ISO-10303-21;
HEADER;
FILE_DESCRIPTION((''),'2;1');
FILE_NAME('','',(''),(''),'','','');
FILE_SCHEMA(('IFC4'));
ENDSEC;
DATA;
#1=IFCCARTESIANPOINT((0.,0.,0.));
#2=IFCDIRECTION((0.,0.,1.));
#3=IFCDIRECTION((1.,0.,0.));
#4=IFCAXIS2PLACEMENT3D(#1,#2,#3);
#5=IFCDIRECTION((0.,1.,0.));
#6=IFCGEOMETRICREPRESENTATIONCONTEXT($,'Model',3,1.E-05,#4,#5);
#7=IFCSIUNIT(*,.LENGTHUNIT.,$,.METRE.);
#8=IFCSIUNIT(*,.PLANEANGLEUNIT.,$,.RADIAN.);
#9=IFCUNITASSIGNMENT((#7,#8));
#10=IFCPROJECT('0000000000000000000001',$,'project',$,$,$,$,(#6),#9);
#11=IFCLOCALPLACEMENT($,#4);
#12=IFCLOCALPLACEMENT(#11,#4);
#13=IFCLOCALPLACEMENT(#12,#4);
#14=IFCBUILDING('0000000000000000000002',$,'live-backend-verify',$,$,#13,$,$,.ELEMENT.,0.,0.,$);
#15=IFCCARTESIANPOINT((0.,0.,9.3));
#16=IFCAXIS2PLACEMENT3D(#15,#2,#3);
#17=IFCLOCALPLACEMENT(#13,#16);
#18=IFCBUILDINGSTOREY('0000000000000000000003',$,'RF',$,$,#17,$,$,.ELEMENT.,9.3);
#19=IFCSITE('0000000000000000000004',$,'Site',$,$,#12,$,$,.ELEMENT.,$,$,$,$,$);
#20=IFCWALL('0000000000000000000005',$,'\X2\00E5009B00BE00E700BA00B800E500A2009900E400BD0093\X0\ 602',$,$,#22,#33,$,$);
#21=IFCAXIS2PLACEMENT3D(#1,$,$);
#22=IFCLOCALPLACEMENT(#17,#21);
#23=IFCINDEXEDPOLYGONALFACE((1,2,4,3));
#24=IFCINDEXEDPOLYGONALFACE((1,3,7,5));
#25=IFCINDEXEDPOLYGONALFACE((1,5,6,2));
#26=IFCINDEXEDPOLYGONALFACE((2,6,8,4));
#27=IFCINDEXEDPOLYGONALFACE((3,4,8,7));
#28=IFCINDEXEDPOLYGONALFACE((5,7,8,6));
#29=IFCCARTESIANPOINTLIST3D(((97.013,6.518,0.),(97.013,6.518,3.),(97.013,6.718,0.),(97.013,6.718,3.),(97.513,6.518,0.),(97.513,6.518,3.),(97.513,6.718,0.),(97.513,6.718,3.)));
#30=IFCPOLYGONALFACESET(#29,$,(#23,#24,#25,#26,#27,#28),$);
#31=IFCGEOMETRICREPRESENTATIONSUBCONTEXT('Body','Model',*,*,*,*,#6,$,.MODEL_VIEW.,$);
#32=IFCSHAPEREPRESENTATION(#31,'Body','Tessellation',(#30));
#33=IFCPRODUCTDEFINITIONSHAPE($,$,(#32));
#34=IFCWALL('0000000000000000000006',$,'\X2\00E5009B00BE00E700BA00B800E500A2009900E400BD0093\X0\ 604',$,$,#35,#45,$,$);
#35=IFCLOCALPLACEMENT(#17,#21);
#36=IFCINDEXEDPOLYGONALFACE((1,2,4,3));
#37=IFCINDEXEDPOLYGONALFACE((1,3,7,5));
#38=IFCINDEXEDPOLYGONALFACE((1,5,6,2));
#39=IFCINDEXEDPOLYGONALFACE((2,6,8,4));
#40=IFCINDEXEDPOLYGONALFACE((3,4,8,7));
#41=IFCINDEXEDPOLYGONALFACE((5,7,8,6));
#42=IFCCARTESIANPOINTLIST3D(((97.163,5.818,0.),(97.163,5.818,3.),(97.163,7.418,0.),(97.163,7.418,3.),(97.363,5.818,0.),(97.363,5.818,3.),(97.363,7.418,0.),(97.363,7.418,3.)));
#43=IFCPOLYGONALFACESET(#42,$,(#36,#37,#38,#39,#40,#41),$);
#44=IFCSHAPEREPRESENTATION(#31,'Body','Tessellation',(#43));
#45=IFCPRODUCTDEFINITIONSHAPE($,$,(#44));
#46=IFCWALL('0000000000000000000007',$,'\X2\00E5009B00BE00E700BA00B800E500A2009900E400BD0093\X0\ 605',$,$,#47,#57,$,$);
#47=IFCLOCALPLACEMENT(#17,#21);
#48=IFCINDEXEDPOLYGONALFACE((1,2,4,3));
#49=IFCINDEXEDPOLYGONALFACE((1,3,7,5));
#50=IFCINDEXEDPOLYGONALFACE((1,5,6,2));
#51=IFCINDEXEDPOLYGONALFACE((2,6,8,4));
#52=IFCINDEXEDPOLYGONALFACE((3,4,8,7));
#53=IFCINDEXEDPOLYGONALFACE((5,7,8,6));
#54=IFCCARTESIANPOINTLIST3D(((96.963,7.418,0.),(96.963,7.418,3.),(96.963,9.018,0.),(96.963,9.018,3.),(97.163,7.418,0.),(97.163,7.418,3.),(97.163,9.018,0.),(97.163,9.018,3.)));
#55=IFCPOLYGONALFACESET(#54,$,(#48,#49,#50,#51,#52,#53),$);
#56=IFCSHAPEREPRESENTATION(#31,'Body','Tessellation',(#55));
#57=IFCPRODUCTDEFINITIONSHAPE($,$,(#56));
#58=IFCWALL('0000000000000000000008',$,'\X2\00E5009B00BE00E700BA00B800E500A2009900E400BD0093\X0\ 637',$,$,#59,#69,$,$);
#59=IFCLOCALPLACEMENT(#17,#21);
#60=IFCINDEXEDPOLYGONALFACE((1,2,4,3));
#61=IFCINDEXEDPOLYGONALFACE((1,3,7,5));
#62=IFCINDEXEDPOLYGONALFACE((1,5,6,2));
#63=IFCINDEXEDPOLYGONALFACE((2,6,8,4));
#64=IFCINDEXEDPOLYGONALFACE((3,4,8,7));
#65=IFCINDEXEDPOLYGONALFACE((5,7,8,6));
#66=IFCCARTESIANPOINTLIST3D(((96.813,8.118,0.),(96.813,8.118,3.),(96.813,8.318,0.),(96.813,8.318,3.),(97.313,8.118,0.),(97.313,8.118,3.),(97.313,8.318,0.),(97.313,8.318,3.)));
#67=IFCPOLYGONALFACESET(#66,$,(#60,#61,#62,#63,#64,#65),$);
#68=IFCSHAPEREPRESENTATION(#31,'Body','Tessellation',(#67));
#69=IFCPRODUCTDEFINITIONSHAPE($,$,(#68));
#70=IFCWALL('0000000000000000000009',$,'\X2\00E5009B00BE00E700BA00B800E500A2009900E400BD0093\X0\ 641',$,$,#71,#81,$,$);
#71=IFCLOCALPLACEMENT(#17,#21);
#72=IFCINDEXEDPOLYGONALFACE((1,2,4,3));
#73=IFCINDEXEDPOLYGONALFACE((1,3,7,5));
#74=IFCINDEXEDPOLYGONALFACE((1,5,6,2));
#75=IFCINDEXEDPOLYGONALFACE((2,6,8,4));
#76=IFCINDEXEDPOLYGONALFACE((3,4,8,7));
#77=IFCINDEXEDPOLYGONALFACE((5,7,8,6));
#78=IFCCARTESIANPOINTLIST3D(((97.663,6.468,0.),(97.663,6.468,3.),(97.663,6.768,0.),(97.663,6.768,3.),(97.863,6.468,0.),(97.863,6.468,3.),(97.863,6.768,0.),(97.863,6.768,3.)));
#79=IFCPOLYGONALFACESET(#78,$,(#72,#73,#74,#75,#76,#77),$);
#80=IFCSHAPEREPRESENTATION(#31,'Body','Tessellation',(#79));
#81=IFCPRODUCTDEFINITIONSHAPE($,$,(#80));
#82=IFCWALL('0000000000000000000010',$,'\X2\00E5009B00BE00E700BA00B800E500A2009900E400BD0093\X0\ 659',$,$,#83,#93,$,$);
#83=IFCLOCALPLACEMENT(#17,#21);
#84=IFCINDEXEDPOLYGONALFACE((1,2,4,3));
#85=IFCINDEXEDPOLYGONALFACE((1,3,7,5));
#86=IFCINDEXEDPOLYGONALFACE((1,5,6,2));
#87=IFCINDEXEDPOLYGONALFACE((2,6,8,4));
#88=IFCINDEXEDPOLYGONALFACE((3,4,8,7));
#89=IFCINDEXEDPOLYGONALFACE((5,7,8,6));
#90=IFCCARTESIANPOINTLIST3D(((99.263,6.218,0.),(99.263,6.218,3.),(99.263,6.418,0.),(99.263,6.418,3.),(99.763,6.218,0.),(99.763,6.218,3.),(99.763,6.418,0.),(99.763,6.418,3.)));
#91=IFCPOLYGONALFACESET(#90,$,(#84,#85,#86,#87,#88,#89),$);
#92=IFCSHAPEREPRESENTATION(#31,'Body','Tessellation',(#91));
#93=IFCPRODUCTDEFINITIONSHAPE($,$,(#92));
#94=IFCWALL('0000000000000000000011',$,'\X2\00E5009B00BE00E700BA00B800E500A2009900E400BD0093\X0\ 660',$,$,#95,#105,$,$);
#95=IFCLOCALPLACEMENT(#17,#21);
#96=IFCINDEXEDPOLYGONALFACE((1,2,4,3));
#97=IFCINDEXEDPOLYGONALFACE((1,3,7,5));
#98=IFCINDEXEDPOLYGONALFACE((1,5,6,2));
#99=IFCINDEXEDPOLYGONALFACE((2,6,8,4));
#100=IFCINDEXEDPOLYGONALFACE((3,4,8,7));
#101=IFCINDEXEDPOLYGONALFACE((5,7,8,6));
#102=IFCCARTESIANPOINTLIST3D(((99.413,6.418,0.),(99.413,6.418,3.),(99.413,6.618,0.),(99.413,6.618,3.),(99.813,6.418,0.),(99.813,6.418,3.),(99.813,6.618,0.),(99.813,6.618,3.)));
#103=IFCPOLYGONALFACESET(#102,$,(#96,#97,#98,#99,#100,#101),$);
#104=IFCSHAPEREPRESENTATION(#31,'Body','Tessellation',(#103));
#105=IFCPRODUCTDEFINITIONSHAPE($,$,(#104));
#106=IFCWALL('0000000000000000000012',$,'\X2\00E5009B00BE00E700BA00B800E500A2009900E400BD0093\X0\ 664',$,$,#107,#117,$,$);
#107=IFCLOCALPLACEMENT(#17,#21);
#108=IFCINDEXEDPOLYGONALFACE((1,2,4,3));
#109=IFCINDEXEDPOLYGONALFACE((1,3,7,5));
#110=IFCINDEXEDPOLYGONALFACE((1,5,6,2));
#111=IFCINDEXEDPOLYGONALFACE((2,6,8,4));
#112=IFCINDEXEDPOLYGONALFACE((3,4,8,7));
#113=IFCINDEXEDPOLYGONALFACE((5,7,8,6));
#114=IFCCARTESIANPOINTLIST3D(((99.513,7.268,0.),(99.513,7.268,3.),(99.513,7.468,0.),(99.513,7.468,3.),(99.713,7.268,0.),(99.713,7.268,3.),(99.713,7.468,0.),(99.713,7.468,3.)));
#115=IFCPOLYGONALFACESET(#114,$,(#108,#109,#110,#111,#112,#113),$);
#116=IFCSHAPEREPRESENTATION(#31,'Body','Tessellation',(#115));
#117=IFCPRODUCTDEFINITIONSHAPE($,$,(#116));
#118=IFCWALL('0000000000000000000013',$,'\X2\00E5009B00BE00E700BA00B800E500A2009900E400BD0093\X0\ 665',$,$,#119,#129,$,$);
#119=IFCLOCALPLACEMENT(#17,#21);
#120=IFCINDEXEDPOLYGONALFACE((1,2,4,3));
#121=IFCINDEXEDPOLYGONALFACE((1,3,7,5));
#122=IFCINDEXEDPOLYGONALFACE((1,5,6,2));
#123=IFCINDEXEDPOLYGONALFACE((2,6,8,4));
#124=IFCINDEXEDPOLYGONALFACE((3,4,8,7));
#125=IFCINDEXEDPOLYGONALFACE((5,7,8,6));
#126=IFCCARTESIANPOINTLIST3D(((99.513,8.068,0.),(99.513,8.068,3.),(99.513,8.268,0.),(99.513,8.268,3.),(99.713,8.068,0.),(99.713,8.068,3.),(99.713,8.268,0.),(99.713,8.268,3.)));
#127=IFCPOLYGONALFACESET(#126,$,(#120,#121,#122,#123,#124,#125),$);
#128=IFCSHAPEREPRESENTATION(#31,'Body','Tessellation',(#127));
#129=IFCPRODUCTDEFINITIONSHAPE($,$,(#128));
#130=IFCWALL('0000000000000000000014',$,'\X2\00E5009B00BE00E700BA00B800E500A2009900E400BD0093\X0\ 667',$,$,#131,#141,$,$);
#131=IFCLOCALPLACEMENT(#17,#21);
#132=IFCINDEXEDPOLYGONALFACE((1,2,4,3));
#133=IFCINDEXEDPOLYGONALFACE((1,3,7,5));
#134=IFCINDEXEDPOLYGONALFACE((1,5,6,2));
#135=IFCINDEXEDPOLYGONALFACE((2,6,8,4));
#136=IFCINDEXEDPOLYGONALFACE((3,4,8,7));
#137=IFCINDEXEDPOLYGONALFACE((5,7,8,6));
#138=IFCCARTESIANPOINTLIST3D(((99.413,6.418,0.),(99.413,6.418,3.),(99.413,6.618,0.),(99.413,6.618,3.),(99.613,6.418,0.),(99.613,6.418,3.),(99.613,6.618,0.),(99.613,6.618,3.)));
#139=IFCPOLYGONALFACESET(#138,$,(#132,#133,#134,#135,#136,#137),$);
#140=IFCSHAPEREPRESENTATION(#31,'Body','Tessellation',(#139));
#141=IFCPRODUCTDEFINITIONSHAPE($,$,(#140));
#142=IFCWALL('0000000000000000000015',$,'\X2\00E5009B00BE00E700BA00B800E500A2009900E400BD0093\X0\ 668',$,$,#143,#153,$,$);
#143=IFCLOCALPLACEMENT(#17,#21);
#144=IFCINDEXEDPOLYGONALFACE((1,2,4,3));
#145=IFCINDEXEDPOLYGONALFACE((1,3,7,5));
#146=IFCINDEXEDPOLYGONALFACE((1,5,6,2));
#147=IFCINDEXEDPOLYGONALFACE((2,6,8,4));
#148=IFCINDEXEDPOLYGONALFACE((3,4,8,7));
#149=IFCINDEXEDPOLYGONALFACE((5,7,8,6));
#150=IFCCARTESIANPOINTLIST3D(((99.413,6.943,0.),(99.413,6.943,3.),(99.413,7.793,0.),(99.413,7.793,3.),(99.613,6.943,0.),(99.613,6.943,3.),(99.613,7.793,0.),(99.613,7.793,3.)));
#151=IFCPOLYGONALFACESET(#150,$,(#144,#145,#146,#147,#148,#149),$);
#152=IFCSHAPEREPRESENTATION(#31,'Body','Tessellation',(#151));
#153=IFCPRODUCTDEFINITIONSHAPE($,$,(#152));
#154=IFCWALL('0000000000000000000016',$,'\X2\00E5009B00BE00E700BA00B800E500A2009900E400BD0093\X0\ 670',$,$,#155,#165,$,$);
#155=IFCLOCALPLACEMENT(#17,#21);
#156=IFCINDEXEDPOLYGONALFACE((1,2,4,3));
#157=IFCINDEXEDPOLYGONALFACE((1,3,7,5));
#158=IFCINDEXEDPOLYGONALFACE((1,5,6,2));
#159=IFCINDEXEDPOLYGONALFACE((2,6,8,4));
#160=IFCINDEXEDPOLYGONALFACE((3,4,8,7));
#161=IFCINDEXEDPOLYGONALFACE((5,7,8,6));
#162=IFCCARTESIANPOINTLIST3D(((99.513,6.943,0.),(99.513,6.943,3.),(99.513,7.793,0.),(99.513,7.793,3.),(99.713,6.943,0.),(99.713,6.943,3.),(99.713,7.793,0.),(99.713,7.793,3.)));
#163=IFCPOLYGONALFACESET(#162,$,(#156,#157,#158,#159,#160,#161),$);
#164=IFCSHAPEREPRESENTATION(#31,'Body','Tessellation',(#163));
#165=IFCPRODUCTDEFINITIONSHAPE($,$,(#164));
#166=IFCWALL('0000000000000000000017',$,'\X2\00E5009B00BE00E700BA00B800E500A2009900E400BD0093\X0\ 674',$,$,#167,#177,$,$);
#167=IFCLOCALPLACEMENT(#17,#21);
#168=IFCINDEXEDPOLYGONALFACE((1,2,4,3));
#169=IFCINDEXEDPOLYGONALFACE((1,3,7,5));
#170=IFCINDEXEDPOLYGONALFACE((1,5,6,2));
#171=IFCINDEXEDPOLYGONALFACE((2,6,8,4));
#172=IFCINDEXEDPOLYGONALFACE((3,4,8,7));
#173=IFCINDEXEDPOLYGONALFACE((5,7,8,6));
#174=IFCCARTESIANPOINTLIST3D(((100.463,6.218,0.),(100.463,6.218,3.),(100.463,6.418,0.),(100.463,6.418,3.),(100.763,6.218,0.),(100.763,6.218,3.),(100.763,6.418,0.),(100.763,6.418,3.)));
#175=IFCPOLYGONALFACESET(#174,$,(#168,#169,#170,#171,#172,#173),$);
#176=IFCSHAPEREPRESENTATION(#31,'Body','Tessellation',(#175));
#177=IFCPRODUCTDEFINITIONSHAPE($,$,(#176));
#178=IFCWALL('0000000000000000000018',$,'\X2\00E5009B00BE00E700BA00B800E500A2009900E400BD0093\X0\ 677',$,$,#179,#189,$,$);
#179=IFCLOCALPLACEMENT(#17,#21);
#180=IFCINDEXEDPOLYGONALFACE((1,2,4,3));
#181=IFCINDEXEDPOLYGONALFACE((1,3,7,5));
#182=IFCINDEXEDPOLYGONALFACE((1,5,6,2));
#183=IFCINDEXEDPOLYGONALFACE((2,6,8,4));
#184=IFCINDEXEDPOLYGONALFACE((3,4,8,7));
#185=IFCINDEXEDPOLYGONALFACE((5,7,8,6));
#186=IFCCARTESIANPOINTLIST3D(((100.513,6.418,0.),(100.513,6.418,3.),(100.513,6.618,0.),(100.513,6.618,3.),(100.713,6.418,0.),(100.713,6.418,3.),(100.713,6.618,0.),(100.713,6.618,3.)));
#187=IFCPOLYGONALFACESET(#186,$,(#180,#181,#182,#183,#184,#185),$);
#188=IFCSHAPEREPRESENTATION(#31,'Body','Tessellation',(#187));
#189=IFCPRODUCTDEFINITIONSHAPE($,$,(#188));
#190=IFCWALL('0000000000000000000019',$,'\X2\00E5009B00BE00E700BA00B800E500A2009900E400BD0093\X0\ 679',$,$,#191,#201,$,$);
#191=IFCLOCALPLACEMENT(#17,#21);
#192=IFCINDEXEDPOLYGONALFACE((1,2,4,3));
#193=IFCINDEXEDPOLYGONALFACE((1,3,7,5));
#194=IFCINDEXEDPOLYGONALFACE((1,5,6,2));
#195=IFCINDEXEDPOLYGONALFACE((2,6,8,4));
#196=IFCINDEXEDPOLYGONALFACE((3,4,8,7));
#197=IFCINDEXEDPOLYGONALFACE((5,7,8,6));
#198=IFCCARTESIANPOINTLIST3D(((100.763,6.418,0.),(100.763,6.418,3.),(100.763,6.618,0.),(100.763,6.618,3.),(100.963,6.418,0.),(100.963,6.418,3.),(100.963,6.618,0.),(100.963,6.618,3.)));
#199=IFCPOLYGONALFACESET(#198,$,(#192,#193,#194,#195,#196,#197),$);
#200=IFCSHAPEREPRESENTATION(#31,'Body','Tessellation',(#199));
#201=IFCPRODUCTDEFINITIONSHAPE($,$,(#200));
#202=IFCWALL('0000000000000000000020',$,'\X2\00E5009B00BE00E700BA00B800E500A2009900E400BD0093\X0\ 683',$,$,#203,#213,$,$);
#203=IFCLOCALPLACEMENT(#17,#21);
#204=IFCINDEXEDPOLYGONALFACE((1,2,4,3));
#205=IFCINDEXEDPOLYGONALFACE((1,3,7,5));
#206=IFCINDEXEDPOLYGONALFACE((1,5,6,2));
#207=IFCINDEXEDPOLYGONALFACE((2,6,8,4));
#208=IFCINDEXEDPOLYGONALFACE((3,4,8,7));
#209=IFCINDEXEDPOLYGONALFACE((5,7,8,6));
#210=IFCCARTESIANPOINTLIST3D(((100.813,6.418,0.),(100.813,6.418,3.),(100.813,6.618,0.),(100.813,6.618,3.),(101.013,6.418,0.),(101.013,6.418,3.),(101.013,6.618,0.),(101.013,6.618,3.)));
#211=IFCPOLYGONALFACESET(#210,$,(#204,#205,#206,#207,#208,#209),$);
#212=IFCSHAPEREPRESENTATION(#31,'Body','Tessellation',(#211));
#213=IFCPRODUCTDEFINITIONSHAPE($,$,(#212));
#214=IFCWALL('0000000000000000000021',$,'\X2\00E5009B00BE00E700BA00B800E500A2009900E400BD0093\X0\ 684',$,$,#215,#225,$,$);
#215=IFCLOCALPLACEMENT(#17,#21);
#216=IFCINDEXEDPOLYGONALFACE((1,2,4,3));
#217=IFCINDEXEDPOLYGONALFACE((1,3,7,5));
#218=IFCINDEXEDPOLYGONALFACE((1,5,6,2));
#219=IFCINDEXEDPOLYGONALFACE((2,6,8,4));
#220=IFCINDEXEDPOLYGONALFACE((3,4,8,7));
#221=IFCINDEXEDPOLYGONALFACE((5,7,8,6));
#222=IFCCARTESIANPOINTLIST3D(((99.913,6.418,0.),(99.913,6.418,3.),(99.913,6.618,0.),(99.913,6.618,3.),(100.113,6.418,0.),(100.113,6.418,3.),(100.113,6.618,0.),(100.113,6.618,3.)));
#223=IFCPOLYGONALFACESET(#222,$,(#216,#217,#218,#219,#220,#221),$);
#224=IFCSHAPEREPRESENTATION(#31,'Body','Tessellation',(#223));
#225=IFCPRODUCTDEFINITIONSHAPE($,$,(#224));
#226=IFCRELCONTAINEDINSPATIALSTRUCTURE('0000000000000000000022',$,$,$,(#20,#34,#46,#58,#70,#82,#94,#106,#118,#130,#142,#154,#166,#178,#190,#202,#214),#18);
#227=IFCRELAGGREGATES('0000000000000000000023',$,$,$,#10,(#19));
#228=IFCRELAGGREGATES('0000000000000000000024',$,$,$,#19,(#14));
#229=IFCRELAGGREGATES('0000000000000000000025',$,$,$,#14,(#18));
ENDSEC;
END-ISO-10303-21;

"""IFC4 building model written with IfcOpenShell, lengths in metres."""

from ifc_helpers import new_model, si_unit, direction, frame, frame_2d, origin_with_axes, place, context, subcontext, project, spatial, rectangle, extrude, element, save


model = new_model("IFC4")

# Units and contexts
model_context = context("Model", 3, precision=1e-05, world=origin_with_axes(), true_north=direction((0.0, 1.0, 0.0)))
body_context = subcontext(model_context, "Body", "Model", "MODEL_VIEW")
ifc_project = project(units=[si_unit("LENGTHUNIT", "METRE"), si_unit("PLANEANGLEUNIT", "RADIAN")], contexts=[model_context])

# Site, building, storey
placement = place(None, origin_with_axes())
site_placement = place(placement, origin_with_axes())
site = spatial("IfcSite", under=ifc_project, at=site_placement, Name="Site", CompositionType="ELEMENT")
building_placement = place(site_placement, origin_with_axes())
building = spatial("IfcBuilding", under=site, at=building_placement, Name="live-backend-verify", CompositionType="ELEMENT", ElevationOfRefHeight=0.0, ElevationOfTerrain=0.0)
storey_placement = place(building_placement, frame((0.0, 0.0, 9.3), z_axis=(0.0, 0.0, 1.0), x_axis=(1.0, 0.0, 0.0)))
storey = spatial("IfcBuildingStorey", under=building, at=storey_placement, Name="RF", CompositionType="ELEMENT", Elevation=9.3)

# Walls
wall_1_placement = place(storey_placement, frame((97.263, 6.618, 0.0), z_axis=(0.0, 0.0, 1.0), x_axis=(1.0, 0.0, 0.0)))
element("IfcWall", 1, at=wall_1_placement, inside=storey, Name="å\u009b¾çº¸å¢\u0099ä½\u0093 602", context=body_context, shape_type="SweptSolid", body=[
    extrude(rectangle(XDim=0.5, YDim=0.2, at=frame_2d((0.0, 0.0), x_axis=(1.0, 0.0, 0.0))), frame((0.0, 0.0, 0.0), z_axis=(0.0, 0.0, 1.0)), (0.0, 0.0, 1.0), 3.0),
])
for number, where, z_axis, x_axis, name in (
    (2, (97.263, 6.618, 0.0), (0.0, 0.0, 1.0), (0.0, 1.0, 0.0), "å\u009b¾çº¸å¢\u0099ä½\u0093 604"),
    (3, (97.063, 8.218, 0.0), (0.0, 0.0, 1.0), (0.0, -1.0, 0.0), "å\u009b¾çº¸å¢\u0099ä½\u0093 605"),
):
    element("IfcWall", number, at=place(storey_placement, frame(where, z_axis=z_axis, x_axis=x_axis)), inside=storey, Name=name, context=body_context, shape_type="SweptSolid", body=[
        extrude(rectangle(XDim=1.6, YDim=0.2, at=frame_2d((0.0, 0.0), x_axis=(1.0, 0.0, 0.0))), frame((0.0, 0.0, 0.0), z_axis=(0.0, 0.0, 1.0)), (0.0, 0.0, 1.0), 3.0),
    ])
wall_2_placement = place(storey_placement, frame((97.063, 8.218, 0.0), z_axis=(0.0, 0.0, 1.0), x_axis=(-1.0, 0.0, 0.0)))
element("IfcWall", 4, at=wall_2_placement, inside=storey, Name="å\u009b¾çº¸å¢\u0099ä½\u0093 637", context=body_context, shape_type="SweptSolid", body=[
    extrude(rectangle(XDim=0.5, YDim=0.2, at=frame_2d((0.0, 0.0), x_axis=(1.0, 0.0, 0.0))), frame((0.0, 0.0, 0.0), z_axis=(0.0, 0.0, 1.0)), (0.0, 0.0, 1.0), 3.0),
])
wall_3_placement = place(storey_placement, frame((97.763, 6.618, 0.0), z_axis=(0.0, 0.0, 1.0), x_axis=(0.0, -1.0, 0.0)))
element("IfcWall", 5, at=wall_3_placement, inside=storey, Name="å\u009b¾çº¸å¢\u0099ä½\u0093 641", context=body_context, shape_type="SweptSolid", body=[
    extrude(rectangle(XDim=0.3, YDim=0.2, at=frame_2d((0.0, 0.0), x_axis=(1.0, 0.0, 0.0))), frame((0.0, 0.0, 0.0), z_axis=(0.0, 0.0, 1.0)), (0.0, 0.0, 1.0), 3.0),
])
for number, where, z_axis, x_axis, name in (
    (6, (99.513, 6.318, 0.0), (0.0, 0.0, 1.0), (1.0, 0.0, 0.0), "å\u009b¾çº¸å¢\u0099ä½\u0093 659"),
):
    element("IfcWall", number, at=place(storey_placement, frame(where, z_axis=z_axis, x_axis=x_axis)), inside=storey, Name=name, context=body_context, shape_type="SweptSolid", body=[
        extrude(rectangle(XDim=0.5, YDim=0.2, at=frame_2d((0.0, 0.0), x_axis=(1.0, 0.0, 0.0))), frame((0.0, 0.0, 0.0), z_axis=(0.0, 0.0, 1.0)), (0.0, 0.0, 1.0), 3.0),
    ])
wall_4_placement = place(storey_placement, frame((99.613, 6.518, 0.0), z_axis=(0.0, 0.0, 1.0), x_axis=(1.0, 0.0, 0.0)))
element("IfcWall", 7, at=wall_4_placement, inside=storey, Name="å\u009b¾çº¸å¢\u0099ä½\u0093 660", context=body_context, shape_type="SweptSolid", body=[
    extrude(rectangle(XDim=0.4, YDim=0.2, at=frame_2d((0.0, 0.0), x_axis=(1.0, 0.0, 0.0))), frame((0.0, 0.0, 0.0), z_axis=(0.0, 0.0, 1.0)), (0.0, 0.0, 1.0), 3.0),
])
for number, where, z_axis, x_axis, name in (
    (8, (99.613, 7.368, 0.0), (0.0, 0.0, 1.0), (-1.0, 0.0, 0.0), "å\u009b¾çº¸å¢\u0099ä½\u0093 664"),
    (9, (99.613, 8.168, 0.0), (0.0, 0.0, 1.0), (-1.0, 0.0, 0.0), "å\u009b¾çº¸å¢\u0099ä½\u0093 665"),
    (10, (99.513, 6.518, 0.0), (0.0, 0.0, 1.0), (0.0, -1.0, 0.0), "å\u009b¾çº¸å¢\u0099ä½\u0093 667"),
):
    element("IfcWall", number, at=place(storey_placement, frame(where, z_axis=z_axis, x_axis=x_axis)), inside=storey, Name=name, context=body_context, shape_type="SweptSolid", body=[
        extrude(rectangle(XDim=0.2, YDim=0.2, at=frame_2d((0.0, 0.0), x_axis=(1.0, 0.0, 0.0))), frame((0.0, 0.0, 0.0), z_axis=(0.0, 0.0, 1.0)), (0.0, 0.0, 1.0), 3.0),
    ])
for number, where, z_axis, x_axis, name in (
    (11, (99.513, 7.368, 0.0), (0.0, 0.0, 1.0), (0.0, -1.0, 0.0), "å\u009b¾çº¸å¢\u0099ä½\u0093 668"),
    (12, (99.613, 7.368, 0.0), (0.0, 0.0, 1.0), (0.0, -1.0, 0.0), "å\u009b¾çº¸å¢\u0099ä½\u0093 670"),
):
    element("IfcWall", number, at=place(storey_placement, frame(where, z_axis=z_axis, x_axis=x_axis)), inside=storey, Name=name, context=body_context, shape_type="SweptSolid", body=[
        extrude(rectangle(XDim=0.85, YDim=0.2, at=frame_2d((0.0, 0.0), x_axis=(1.0, 0.0, 0.0))), frame((0.0, 0.0, 0.0), z_axis=(0.0, 0.0, 1.0)), (0.0, 0.0, 1.0), 3.0),
    ])
wall_5_placement = place(storey_placement, frame((100.613, 6.318, 0.0), z_axis=(0.0, 0.0, 1.0), x_axis=(1.0, 0.0, 0.0)))
element("IfcWall", 13, at=wall_5_placement, inside=storey, Name="å\u009b¾çº¸å¢\u0099ä½\u0093 674", context=body_context, shape_type="SweptSolid", body=[
    extrude(rectangle(XDim=0.3, YDim=0.2, at=frame_2d((0.0, 0.0), x_axis=(1.0, 0.0, 0.0))), frame((0.0, 0.0, 0.0), z_axis=(0.0, 0.0, 1.0)), (0.0, 0.0, 1.0), 3.0),
])
for number, where, z_axis, x_axis, name in (
    (14, (100.613, 6.518, 0.0), (0.0, 0.0, 1.0), (1.0, 0.0, 0.0), "å\u009b¾çº¸å¢\u0099ä½\u0093 677"),
    (15, (100.863, 6.518, 0.0), (0.0, 0.0, 1.0), (1.0, 0.0, 0.0), "å\u009b¾çº¸å¢\u0099ä½\u0093 679"),
    (16, (100.913, 6.518, 0.0), (0.0, 0.0, 1.0), (0.0, -1.0, 0.0), "å\u009b¾çº¸å¢\u0099ä½\u0093 683"),
    (17, (100.013, 6.518, 0.0), (0.0, 0.0, 1.0), (0.0, -1.0, 0.0), "å\u009b¾çº¸å¢\u0099ä½\u0093 684"),
):
    element("IfcWall", number, at=place(storey_placement, frame(where, z_axis=z_axis, x_axis=x_axis)), inside=storey, Name=name, context=body_context, shape_type="SweptSolid", body=[
        extrude(rectangle(XDim=0.2, YDim=0.2, at=frame_2d((0.0, 0.0), x_axis=(1.0, 0.0, 0.0))), frame((0.0, 0.0, 0.0), z_axis=(0.0, 0.0, 1.0)), (0.0, 0.0, 1.0), 3.0),
    ])

save(model, "model.ifc")
